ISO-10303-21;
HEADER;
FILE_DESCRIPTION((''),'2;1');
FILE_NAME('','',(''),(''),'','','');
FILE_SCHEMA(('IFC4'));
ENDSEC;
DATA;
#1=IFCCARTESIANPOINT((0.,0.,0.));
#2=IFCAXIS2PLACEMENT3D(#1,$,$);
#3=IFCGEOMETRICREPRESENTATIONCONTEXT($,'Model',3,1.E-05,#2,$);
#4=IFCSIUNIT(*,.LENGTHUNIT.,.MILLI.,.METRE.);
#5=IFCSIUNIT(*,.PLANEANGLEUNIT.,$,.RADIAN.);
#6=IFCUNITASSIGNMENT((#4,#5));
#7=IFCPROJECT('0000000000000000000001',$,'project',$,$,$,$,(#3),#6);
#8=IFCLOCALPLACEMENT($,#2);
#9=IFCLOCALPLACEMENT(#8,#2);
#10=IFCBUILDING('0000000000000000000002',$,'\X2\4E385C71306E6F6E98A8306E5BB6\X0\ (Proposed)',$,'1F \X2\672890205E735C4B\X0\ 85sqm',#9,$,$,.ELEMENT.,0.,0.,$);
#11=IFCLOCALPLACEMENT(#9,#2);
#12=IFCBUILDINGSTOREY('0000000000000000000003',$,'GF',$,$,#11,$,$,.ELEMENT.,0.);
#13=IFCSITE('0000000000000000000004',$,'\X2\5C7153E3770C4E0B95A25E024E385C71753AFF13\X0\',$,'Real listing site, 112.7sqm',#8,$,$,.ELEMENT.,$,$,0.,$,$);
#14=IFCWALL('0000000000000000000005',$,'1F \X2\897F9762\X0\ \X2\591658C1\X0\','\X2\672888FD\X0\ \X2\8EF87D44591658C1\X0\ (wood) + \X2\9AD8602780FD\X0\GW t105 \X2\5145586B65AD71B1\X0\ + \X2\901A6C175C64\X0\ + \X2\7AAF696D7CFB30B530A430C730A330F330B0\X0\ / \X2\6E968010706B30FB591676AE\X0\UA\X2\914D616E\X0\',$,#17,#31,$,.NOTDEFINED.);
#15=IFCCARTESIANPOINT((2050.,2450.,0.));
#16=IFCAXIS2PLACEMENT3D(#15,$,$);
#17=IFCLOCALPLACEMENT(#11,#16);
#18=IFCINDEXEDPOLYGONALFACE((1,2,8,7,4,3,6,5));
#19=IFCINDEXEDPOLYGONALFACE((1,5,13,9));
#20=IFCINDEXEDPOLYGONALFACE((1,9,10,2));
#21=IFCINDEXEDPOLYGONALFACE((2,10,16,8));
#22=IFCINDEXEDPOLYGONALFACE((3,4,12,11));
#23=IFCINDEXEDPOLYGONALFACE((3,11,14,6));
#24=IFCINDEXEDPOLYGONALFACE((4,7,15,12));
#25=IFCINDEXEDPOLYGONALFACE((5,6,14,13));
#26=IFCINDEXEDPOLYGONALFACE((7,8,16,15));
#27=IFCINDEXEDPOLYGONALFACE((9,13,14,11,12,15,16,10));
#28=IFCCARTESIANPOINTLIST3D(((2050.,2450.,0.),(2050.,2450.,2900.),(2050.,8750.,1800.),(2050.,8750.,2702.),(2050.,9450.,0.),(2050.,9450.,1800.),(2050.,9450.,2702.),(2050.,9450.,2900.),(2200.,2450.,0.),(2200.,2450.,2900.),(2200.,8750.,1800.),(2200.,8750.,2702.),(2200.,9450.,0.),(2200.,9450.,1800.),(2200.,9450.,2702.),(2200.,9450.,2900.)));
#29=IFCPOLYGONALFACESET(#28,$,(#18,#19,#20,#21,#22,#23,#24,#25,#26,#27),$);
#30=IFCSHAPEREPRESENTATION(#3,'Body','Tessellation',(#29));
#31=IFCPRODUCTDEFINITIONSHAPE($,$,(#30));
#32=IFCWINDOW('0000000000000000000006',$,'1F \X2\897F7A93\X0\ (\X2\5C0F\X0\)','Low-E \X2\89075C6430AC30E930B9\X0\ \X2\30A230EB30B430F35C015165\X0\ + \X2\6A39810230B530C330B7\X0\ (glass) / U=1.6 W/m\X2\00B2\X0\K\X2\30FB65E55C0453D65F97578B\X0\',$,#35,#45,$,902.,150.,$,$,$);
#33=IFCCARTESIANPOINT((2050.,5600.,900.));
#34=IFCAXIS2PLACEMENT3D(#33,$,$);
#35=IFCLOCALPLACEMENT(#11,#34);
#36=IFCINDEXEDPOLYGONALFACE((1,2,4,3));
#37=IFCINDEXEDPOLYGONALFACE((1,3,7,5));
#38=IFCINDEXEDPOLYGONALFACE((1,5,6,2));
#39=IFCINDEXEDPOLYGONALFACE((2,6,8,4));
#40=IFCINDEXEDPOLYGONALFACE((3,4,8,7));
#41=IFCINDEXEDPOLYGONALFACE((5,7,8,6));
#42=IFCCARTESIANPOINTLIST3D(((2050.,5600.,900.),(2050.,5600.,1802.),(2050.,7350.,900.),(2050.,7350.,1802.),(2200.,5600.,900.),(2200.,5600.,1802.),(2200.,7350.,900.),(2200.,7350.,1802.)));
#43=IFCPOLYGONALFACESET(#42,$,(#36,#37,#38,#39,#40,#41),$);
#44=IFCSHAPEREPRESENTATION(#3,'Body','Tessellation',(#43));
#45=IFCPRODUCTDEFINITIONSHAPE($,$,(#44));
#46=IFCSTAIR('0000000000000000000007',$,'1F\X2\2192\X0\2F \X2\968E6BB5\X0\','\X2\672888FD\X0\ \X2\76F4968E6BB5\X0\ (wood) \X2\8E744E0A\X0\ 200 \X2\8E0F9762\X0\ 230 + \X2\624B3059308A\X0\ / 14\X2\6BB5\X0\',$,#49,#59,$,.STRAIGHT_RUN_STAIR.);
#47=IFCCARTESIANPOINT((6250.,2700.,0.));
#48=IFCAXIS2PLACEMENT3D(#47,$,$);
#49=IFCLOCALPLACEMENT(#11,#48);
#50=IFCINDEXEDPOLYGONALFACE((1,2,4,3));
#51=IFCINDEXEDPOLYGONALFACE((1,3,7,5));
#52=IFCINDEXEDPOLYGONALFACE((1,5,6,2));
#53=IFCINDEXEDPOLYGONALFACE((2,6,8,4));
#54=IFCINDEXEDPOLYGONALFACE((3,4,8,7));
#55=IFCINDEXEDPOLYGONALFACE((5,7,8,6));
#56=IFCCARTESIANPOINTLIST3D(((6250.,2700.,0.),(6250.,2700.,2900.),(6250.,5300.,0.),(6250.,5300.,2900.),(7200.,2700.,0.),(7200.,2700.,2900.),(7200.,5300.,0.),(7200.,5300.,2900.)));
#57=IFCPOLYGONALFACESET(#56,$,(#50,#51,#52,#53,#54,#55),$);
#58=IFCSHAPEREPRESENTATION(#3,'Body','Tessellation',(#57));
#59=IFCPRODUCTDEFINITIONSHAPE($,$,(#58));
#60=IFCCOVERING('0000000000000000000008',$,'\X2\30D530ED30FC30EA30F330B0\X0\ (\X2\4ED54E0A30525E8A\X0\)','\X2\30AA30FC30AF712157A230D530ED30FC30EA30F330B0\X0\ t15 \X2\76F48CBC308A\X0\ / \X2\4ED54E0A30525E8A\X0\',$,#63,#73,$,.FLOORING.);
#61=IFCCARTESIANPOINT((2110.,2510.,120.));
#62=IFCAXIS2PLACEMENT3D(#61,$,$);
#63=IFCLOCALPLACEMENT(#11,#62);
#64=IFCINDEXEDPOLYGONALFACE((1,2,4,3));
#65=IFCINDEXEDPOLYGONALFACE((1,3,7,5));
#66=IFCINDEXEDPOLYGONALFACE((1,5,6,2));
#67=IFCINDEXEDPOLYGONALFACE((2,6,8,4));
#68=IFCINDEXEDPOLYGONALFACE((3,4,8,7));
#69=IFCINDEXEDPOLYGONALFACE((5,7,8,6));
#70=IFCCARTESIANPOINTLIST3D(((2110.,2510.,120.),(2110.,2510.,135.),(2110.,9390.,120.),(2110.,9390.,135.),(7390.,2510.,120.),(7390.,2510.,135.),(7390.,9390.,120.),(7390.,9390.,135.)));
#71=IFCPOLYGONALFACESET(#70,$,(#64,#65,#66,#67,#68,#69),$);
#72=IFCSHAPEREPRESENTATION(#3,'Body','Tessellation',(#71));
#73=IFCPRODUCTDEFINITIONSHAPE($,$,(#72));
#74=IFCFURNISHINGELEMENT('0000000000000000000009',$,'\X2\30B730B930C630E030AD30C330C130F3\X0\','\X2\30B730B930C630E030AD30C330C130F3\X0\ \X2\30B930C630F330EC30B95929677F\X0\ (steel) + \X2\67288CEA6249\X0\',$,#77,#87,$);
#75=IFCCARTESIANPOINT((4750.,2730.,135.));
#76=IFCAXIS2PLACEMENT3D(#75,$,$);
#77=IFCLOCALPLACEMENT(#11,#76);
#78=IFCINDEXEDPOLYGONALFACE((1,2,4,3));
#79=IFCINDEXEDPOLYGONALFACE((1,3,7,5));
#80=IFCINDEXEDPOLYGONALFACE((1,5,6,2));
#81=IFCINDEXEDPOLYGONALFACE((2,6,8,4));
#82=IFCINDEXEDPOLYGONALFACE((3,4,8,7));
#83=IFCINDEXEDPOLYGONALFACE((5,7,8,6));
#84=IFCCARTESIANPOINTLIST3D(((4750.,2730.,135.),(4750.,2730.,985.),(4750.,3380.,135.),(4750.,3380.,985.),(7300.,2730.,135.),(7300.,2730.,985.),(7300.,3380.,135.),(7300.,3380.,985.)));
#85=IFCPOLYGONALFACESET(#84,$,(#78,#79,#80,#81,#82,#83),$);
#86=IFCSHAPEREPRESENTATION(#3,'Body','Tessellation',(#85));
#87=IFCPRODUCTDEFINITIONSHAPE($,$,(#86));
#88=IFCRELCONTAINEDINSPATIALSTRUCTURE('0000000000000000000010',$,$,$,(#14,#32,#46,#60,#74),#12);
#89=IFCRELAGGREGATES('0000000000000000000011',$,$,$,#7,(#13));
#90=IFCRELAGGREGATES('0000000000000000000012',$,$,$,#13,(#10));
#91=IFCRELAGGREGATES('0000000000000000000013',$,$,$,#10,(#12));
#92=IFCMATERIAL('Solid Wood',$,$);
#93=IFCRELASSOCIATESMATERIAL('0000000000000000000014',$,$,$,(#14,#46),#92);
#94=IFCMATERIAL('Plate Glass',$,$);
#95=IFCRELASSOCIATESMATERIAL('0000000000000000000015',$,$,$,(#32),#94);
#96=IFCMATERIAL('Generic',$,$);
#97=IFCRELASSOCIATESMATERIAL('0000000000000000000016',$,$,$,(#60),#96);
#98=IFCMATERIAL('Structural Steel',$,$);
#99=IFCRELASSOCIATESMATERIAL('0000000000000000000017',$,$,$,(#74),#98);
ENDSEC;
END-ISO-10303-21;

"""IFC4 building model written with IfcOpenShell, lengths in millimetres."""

from ifc_helpers import new_model, si_unit, frame, frame_2d, origin, place, context, project, spatial, rectangle, extrude, material, element, fill, save


model = new_model("IFC4")

# Units and contexts
model_context = context("Model", 3, precision=1e-05, world=origin())
ifc_project = project(units=[si_unit("LENGTHUNIT", "METRE", prefix="MILLI"), si_unit("PLANEANGLEUNIT", "RADIAN")], contexts=[model_context])

# Site, building, storey
site_placement = place(None, origin())
site = spatial("IfcSite", under=ifc_project, at=site_placement, Name="山口県下関市丸山町３", ObjectType="Real listing site, 112.7sqm", CompositionType="ELEMENT", RefElevation=0.0)
building_placement = place(site_placement, origin())
building = spatial("IfcBuilding", under=site, at=building_placement, Name="丸山の潮風の家 (Proposed)", ObjectType="1F 木造平屋 85sqm", CompositionType="ELEMENT", ElevationOfRefHeight=0.0, ElevationOfTerrain=0.0)
storey_placement = place(building_placement, origin())
storey = spatial("IfcBuildingStorey", under=building, at=storey_placement, Name="GF", CompositionType="ELEMENT", Elevation=0.0)

# Shared definitions
ifc_material_1 = material(Name="Solid Wood")
ifc_material_2 = material(Name="Generic")

# Shared definitions
ifc_material_3 = material(Name="Plate Glass")

# Wall, opening, window
wall_1_placement = place(storey_placement, frame((2050.0, 2450.0, 0.0)))
wall_1 = element("IfcWall", 1, at=wall_1_placement, inside=storey, material=ifc_material_1, Name="1F 西面 外壁", Description="木製 軸組外壁 (wood) + 高性能GW t105 充填断熱 + 通気層 + 窯業系サイディング / 準耐火・外皮UA配慮", PredefinedType="NOTDEFINED", context=model_context, shape_type="SweptSolid", body=[
    extrude(rectangle(XDim=150.0, YDim=7000.0, at=frame_2d((75.0, 3500.0))), frame((2050.0, 2450.0, 0.0)), (0.0, 0.0, 1.0), 2900.0),
])
opening_1_placement = place(storey_placement, frame((2050.0, 5600.0, 900.0)))
opening_1 = element("IfcOpeningElement", 2, at=opening_1_placement, cuts=wall_1, PredefinedType="NOTDEFINED", context=model_context, shape_type="SweptSolid", body=[
    extrude(rectangle(XDim=150.0, YDim=1750.0, at=frame_2d((75.0, 875.0))), frame((2050.0, 5600.0, 900.0)), (0.0, 0.0, 1.0), 902.0),
])
window_1_placement = place(storey_placement, frame((2050.0, 5600.0, 900.0)))
window_1 = element("IfcWindow", 3, at=window_1_placement, inside=storey, material=ifc_material_3, Name="1F 西窓 (小)", Description="Low-E 複層ガラス アルゴン封入 + 樹脂サッシ (glass) / U=1.6 W/m²K・日射取得型", OverallHeight=902.0, OverallWidth=150.0, context=model_context, shape_type="SweptSolid", body=[
    extrude(rectangle(XDim=150.0, YDim=1750.0, at=frame_2d((75.0, 875.0))), frame((2050.0, 5600.0, 900.0)), (0.0, 0.0, 1.0), 902.0),
])
fill(opening_1, window_1)

# Stair
stair_placement = place(storey_placement, frame((6250.0, 2700.0, 0.0)))
element("IfcStair", 4, at=stair_placement, inside=storey, material=ifc_material_1, Name="1F→2F 階段", Description="木製 直階段 (wood) 蹴上 200 踏面 230 + 手すり / 14段", PredefinedType="STRAIGHT_RUN_STAIR", context=model_context, shape_type="SweptSolid", body=[
    extrude(rectangle(XDim=950.0, YDim=2600.0, at=frame_2d((475.0, 1300.0))), frame((6250.0, 2700.0, 0.0)), (0.0, 0.0, 1.0), 2900.0),
])

# Covering
covering_placement = place(storey_placement, frame((2110.0, 2510.0, 120.0)))
element("IfcCovering", 5, at=covering_placement, inside=storey, material=ifc_material_2, Name="フローリング (仕上げ床)", Description="オーク無垢フローリング t15 直貼り / 仕上げ床", PredefinedType="FLOORING", context=model_context, shape_type="SweptSolid", body=[
    extrude(rectangle(XDim=5280.0, YDim=6880.0, at=frame_2d((2640.0, 3440.0))), frame((2110.0, 2510.0, 120.0)), (0.0, 0.0, 1.0), 15.0),
])

# Furnishing element
ifc_material_4 = material(Name="Structural Steel")
furnishing_placement = place(storey_placement, frame((4750.0, 2730.0, 135.0)))
element("IfcFurnishingElement", 6, at=furnishing_placement, inside=storey, material=ifc_material_4, Name="システムキッチン", Description="システムキッチン ステンレス天板 (steel) + 木質扉", context=model_context, shape_type="SweptSolid", body=[
    extrude(rectangle(XDim=2550.0, YDim=650.0, at=frame_2d((1275.0, 325.0))), frame((4750.0, 2730.0, 135.0)), (0.0, 0.0, 1.0), 850.0),
])

save(model, "model.ifc")
